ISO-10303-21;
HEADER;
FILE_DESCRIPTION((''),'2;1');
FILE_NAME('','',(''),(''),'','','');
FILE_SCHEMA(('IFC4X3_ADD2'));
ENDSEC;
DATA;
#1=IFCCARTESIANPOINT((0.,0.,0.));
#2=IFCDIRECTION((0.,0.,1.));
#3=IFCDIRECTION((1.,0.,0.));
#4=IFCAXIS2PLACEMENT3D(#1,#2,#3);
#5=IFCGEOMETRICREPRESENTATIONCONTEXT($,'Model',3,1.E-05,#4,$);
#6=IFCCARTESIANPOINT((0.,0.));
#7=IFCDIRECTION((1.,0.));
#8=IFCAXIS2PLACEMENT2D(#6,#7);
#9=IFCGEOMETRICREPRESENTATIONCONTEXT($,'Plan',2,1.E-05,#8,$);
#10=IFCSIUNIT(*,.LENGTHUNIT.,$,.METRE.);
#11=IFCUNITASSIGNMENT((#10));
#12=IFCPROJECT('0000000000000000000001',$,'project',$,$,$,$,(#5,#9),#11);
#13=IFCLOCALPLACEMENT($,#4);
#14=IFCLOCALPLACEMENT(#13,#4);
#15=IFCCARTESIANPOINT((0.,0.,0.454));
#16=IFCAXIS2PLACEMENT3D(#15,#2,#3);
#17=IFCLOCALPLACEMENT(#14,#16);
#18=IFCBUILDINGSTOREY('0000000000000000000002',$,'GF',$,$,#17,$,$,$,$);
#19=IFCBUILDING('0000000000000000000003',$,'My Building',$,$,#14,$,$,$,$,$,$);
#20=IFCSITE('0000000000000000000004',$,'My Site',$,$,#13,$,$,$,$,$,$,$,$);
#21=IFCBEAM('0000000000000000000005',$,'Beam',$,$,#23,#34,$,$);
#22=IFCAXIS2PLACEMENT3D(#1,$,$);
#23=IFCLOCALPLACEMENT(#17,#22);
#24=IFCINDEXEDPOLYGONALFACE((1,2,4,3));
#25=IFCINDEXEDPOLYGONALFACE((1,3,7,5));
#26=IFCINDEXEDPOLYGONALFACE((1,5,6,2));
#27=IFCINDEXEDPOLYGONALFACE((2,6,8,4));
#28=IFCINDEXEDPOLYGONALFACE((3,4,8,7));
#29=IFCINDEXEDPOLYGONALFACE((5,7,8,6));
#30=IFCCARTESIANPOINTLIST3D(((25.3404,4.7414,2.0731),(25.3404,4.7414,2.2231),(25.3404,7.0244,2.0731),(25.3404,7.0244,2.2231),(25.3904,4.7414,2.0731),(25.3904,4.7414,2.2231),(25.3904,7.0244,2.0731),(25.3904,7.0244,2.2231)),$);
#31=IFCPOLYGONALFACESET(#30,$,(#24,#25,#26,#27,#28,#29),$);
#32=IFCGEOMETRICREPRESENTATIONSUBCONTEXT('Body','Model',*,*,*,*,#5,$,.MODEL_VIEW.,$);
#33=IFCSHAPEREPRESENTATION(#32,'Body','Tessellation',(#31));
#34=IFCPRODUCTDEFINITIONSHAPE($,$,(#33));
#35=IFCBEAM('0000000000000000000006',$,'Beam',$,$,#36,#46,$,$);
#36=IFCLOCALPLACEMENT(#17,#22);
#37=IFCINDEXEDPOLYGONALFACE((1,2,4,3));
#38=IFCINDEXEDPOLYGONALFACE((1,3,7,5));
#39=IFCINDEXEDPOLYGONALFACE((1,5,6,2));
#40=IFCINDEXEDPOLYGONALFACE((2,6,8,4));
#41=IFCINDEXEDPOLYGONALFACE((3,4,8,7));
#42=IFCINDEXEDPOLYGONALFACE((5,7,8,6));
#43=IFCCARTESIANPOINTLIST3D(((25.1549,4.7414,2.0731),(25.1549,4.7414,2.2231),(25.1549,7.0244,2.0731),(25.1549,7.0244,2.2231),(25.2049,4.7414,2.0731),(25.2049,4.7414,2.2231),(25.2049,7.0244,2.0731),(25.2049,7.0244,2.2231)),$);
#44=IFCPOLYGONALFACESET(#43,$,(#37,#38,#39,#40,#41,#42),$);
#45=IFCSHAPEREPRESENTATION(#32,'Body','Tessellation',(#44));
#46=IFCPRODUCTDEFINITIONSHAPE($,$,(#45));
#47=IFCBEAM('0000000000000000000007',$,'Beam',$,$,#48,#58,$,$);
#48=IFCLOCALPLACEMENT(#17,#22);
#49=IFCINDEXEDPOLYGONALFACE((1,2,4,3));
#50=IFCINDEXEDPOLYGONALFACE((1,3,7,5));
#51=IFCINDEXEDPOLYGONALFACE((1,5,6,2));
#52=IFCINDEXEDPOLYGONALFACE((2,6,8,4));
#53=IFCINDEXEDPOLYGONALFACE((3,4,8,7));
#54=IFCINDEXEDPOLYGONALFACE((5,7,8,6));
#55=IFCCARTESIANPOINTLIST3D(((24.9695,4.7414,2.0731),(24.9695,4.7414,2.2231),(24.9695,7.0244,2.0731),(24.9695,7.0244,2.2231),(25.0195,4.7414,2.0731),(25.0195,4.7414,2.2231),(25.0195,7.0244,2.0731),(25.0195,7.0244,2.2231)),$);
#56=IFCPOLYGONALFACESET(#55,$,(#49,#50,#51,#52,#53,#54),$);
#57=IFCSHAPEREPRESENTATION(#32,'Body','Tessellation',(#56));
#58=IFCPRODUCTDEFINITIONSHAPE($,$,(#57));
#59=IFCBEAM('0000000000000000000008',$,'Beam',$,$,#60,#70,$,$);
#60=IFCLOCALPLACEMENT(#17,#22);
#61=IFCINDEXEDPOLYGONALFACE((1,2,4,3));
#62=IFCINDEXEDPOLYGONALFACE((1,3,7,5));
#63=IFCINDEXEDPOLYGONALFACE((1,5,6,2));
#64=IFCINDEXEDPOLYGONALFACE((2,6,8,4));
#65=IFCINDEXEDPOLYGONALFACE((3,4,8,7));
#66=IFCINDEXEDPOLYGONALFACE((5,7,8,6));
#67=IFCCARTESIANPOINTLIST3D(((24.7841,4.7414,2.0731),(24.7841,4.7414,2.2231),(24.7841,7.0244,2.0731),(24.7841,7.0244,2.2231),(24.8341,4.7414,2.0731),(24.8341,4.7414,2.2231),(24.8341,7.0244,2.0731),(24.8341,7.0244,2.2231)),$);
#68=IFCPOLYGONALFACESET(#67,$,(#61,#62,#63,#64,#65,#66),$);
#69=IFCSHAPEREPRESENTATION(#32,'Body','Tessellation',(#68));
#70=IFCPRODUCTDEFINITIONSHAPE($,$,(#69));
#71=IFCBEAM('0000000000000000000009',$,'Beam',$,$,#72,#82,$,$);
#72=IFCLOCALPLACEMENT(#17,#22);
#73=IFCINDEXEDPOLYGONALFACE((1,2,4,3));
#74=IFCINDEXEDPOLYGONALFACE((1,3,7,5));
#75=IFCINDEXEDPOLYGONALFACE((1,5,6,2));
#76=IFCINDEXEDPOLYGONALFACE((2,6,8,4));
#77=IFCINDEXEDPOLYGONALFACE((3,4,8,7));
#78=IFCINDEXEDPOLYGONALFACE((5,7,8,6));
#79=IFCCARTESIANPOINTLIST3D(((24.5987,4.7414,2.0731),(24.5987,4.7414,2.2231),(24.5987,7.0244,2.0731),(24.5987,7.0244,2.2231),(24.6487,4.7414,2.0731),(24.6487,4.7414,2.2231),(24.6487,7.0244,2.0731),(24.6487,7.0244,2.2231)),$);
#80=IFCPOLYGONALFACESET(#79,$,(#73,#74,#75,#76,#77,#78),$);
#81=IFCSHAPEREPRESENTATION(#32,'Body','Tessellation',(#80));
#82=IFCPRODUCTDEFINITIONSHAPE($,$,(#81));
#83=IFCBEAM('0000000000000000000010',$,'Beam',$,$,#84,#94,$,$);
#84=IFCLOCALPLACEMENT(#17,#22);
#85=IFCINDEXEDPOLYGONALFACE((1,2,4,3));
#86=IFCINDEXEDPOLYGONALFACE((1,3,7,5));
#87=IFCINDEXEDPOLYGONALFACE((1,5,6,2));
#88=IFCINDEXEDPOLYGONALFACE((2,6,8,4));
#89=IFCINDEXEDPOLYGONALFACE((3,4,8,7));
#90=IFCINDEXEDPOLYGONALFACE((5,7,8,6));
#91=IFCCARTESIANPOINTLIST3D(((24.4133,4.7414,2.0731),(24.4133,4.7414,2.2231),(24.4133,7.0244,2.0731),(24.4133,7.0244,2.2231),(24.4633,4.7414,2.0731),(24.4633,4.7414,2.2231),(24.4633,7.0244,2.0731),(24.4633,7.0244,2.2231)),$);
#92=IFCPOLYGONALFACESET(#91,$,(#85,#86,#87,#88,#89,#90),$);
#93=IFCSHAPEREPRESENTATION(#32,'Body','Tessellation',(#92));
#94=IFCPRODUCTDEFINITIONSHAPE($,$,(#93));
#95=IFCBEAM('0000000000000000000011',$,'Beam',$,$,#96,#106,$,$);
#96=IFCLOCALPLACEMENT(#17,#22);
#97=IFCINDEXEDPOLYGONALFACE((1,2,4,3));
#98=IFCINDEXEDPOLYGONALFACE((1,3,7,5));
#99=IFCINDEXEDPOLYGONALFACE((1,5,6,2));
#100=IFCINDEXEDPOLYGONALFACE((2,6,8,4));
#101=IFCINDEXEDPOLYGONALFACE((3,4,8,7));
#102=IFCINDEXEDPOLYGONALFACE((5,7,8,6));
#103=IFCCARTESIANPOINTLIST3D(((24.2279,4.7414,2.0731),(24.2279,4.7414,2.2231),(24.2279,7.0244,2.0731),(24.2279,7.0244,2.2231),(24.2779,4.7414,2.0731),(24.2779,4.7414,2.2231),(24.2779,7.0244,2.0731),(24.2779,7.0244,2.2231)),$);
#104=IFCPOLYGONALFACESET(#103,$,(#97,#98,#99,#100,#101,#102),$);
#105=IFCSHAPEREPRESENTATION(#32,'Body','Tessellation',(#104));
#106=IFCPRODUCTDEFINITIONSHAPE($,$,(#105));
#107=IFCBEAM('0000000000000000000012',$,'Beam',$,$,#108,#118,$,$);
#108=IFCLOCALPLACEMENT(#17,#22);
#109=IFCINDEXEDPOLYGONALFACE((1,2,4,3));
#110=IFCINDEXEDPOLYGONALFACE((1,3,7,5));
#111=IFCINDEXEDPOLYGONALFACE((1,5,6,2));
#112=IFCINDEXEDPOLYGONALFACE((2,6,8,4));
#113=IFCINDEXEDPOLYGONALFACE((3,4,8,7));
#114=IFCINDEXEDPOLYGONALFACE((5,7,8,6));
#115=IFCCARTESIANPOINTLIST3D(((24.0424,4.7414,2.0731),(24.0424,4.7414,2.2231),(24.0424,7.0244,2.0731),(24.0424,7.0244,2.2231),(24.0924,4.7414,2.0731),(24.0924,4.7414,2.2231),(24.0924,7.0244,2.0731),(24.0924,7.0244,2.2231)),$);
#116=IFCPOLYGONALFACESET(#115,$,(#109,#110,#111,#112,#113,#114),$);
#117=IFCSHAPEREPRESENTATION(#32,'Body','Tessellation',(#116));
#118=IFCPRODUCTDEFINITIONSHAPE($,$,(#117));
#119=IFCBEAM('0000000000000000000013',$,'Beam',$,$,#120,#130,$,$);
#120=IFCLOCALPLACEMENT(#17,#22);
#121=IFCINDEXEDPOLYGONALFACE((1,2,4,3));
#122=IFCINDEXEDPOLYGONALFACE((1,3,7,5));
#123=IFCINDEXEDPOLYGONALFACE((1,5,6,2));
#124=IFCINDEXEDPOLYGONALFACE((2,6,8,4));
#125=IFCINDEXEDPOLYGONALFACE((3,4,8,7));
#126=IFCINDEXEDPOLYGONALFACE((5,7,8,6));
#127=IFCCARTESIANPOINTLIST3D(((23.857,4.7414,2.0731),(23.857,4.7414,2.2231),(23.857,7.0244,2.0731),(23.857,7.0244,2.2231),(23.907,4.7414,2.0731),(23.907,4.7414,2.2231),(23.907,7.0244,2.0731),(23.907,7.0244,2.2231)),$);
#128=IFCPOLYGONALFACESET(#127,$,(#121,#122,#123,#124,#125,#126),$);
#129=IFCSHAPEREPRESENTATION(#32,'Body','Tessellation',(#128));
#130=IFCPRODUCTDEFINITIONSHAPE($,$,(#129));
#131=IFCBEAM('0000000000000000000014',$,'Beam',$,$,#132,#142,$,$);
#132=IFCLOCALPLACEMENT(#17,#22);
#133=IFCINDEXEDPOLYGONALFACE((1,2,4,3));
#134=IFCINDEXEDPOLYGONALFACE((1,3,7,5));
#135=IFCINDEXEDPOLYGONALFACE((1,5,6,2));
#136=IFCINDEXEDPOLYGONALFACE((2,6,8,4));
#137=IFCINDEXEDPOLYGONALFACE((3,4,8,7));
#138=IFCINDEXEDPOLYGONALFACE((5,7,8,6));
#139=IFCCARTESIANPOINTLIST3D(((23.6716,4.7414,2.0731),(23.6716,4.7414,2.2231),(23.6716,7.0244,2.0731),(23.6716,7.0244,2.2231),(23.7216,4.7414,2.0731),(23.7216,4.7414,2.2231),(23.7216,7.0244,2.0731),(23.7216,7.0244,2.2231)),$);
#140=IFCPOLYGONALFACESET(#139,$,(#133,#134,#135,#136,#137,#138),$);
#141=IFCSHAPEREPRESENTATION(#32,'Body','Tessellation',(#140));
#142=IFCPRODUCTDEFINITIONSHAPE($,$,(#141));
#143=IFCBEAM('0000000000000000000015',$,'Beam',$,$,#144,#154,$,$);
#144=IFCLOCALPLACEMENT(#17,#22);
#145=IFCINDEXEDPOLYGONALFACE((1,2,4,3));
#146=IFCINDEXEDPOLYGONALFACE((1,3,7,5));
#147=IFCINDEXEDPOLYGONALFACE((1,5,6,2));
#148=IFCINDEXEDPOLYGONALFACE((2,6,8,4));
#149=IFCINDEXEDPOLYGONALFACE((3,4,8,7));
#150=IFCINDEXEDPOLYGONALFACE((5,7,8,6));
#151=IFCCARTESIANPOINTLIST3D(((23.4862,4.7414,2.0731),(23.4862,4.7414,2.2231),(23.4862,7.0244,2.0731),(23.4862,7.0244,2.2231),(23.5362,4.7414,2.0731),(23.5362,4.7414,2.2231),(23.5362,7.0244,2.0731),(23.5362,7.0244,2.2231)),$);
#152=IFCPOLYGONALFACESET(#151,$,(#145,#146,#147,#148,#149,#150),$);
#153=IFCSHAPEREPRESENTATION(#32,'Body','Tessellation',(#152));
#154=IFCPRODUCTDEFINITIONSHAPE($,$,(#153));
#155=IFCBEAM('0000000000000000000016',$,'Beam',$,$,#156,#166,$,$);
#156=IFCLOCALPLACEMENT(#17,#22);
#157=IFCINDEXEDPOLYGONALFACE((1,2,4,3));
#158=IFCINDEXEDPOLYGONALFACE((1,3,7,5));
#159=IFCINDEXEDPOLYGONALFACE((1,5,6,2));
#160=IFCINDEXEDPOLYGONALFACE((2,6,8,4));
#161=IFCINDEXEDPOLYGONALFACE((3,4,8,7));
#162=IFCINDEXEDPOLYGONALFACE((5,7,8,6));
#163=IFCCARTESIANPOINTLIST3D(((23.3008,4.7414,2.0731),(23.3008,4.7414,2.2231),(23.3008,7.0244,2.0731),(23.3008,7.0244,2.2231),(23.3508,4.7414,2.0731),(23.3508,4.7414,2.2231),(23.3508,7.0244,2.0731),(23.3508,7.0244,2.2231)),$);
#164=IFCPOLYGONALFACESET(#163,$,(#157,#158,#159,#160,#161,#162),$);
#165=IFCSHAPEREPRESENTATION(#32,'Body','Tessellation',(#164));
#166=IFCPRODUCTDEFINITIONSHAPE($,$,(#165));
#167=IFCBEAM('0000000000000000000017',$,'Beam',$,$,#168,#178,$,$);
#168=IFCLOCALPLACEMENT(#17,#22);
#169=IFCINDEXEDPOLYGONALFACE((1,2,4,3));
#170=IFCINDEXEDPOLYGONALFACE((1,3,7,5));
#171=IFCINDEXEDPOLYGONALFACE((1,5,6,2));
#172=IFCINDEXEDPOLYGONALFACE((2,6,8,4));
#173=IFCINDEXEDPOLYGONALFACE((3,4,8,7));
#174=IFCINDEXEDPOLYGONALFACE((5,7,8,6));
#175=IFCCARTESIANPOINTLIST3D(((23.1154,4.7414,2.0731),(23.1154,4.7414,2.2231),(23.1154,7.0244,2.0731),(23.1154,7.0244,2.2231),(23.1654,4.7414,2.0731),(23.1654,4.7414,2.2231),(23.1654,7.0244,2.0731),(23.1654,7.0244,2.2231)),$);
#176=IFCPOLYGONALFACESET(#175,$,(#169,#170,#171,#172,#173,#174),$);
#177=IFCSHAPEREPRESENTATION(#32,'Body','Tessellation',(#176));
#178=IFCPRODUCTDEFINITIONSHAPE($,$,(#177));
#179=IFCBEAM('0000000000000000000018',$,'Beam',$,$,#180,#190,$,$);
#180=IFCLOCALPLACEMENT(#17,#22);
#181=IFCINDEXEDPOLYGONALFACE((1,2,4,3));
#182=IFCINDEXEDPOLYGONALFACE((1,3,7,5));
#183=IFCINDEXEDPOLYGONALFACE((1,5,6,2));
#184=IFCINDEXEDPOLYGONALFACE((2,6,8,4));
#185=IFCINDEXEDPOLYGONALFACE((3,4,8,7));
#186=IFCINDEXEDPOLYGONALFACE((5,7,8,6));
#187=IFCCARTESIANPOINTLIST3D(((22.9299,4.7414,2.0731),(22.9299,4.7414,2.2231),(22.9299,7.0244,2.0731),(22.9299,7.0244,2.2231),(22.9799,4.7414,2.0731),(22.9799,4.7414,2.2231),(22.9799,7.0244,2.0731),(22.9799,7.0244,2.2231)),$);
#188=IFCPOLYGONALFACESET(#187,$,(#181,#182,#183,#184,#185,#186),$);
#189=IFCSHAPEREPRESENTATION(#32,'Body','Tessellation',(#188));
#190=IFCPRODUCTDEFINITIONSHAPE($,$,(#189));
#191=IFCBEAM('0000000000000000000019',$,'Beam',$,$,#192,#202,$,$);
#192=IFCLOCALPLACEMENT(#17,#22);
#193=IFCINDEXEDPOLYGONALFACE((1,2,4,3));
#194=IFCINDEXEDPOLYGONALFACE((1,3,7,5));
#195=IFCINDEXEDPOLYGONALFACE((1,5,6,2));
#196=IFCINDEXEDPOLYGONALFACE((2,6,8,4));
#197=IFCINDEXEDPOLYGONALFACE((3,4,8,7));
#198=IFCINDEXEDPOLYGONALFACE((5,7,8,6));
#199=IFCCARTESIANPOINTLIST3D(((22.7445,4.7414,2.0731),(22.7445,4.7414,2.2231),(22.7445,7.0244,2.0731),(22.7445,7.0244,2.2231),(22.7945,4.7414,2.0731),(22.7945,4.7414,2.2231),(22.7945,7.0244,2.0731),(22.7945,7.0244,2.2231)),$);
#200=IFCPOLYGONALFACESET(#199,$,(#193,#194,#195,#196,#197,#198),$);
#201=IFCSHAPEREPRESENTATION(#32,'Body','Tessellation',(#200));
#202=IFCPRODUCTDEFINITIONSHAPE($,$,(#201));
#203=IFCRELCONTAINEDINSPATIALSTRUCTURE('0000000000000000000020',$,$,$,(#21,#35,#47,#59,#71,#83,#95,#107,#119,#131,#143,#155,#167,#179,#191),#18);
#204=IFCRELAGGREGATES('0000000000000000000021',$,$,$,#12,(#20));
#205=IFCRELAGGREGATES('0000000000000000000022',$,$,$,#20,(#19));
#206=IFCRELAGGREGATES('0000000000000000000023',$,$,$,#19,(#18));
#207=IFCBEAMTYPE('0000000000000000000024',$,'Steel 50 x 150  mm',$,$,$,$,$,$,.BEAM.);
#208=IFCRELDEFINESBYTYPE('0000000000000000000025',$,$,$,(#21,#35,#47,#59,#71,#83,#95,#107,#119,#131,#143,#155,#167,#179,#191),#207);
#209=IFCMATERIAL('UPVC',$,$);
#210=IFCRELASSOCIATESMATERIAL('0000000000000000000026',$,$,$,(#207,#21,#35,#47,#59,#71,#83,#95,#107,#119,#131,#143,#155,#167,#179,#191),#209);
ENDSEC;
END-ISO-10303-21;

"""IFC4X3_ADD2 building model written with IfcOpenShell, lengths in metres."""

from ifc_helpers import new_model, si_unit, frame, origin_with_axes, origin_2d_with_axis, place, context, subcontext, project, spatial, rectangle, extrude, material, material_profile, profile_set, profile_usage, type_object, element, save


model = new_model("IFC4X3_ADD2")

# Units and contexts
model_context = context("Model", 3, precision=1e-05, world=origin_with_axes())
plan_context = context("Plan", 2, precision=1e-05, world=origin_2d_with_axis())
body_context_1 = subcontext(model_context, "Body", "Model", "MODEL_VIEW")
ifc_project = project(units=[si_unit("LENGTHUNIT", "METRE")], contexts=[model_context, plan_context])

# Site, building, storey
site_placement = place(None, origin_with_axes())
site = spatial("IfcSite", under=ifc_project, at=site_placement, Name="My Site")
building_placement = place(site_placement, origin_with_axes())
building = spatial("IfcBuilding", under=site, at=building_placement, Name="My Building")
storey_placement = place(building_placement, frame((0.0, 0.0, 0.454), z_axis=(0.0, 0.0, 1.0), x_axis=(1.0, 0.0, 0.0)))
storey = spatial("IfcBuildingStorey", under=building, at=storey_placement, Name="GF")

# Beams
ifc_material_1 = material(Name="UPVC")
ifc_material_profile_1 = material_profile(ifc_material_1, rectangle(XDim=0.05, YDim=0.15))
ifc_profile_set_1 = profile_set([ifc_material_profile_1])
ifc_profile_usage_1 = profile_usage(ifc_profile_set_1)
beam_type_1 = type_object("IfcBeamType", Name="Steel 50 x 150  mm", PredefinedType="BEAM", material=ifc_profile_set_1)
beam_1_placement = place(storey_placement, frame((25.3654, 7.0244, 2.1481), z_axis=(0.0, -1.0, 0.0), x_axis=(1.0, 0.0, 0.0)))
element("IfcBeam", 1, at=beam_1_placement, inside=storey, type_object=beam_type_1, material=ifc_profile_usage_1, Name="Beam", context=body_context_1, shape_type="SweptSolid", body=[
    extrude(rectangle(XDim=0.05, YDim=0.15), origin_with_axes(), (0.0, 0.0, 1.0), 2.283),
])
ifc_profile_usage_2 = profile_usage(ifc_profile_set_1)
beam_2_placement = place(storey_placement, frame((25.1799, 7.0244, 2.1481), z_axis=(0.0, -1.0, 0.0), x_axis=(1.0, 0.0, 0.0)))
element("IfcBeam", 2, at=beam_2_placement, inside=storey, type_object=beam_type_1, material=ifc_profile_usage_2, Name="Beam", context=body_context_1, shape_type="SweptSolid", body=[
    extrude(rectangle(XDim=0.05, YDim=0.15), origin_with_axes(), (0.0, 0.0, 1.0), 2.283),
])
ifc_profile_usage_3 = profile_usage(ifc_profile_set_1)
beam_3_placement = place(storey_placement, frame((24.9945, 7.0244, 2.1481), z_axis=(0.0, -1.0, 0.0), x_axis=(1.0, 0.0, 0.0)))
element("IfcBeam", 3, at=beam_3_placement, inside=storey, type_object=beam_type_1, material=ifc_profile_usage_3, Name="Beam", context=body_context_1, shape_type="SweptSolid", body=[
    extrude(rectangle(XDim=0.05, YDim=0.15), origin_with_axes(), (0.0, 0.0, 1.0), 2.283),
])
ifc_profile_usage_4 = profile_usage(ifc_profile_set_1)
beam_4_placement = place(storey_placement, frame((24.8091, 7.0244, 2.1481), z_axis=(0.0, -1.0, 0.0), x_axis=(1.0, 0.0, 0.0)))
element("IfcBeam", 4, at=beam_4_placement, inside=storey, type_object=beam_type_1, material=ifc_profile_usage_4, Name="Beam", context=body_context_1, shape_type="SweptSolid", body=[
    extrude(rectangle(XDim=0.05, YDim=0.15), origin_with_axes(), (0.0, 0.0, 1.0), 2.283),
])
ifc_profile_usage_5 = profile_usage(ifc_profile_set_1)
beam_5_placement = place(storey_placement, frame((24.6237, 7.0244, 2.1481), z_axis=(0.0, -1.0, 0.0), x_axis=(1.0, 0.0, 0.0)))
element("IfcBeam", 5, at=beam_5_placement, inside=storey, type_object=beam_type_1, material=ifc_profile_usage_5, Name="Beam", context=body_context_1, shape_type="SweptSolid", body=[
    extrude(rectangle(XDim=0.05, YDim=0.15), origin_with_axes(), (0.0, 0.0, 1.0), 2.283),
])
ifc_profile_usage_6 = profile_usage(ifc_profile_set_1)
beam_6_placement = place(storey_placement, frame((24.4383, 7.0244, 2.1481), z_axis=(0.0, -1.0, 0.0), x_axis=(1.0, 0.0, 0.0)))
element("IfcBeam", 6, at=beam_6_placement, inside=storey, type_object=beam_type_1, material=ifc_profile_usage_6, Name="Beam", context=body_context_1, shape_type="SweptSolid", body=[
    extrude(rectangle(XDim=0.05, YDim=0.15), origin_with_axes(), (0.0, 0.0, 1.0), 2.283),
])
ifc_profile_usage_7 = profile_usage(ifc_profile_set_1)
beam_7_placement = place(storey_placement, frame((24.2529, 7.0244, 2.1481), z_axis=(0.0, -1.0, 0.0), x_axis=(1.0, 0.0, 0.0)))
element("IfcBeam", 7, at=beam_7_placement, inside=storey, type_object=beam_type_1, material=ifc_profile_usage_7, Name="Beam", context=body_context_1, shape_type="SweptSolid", body=[
    extrude(rectangle(XDim=0.05, YDim=0.15), origin_with_axes(), (0.0, 0.0, 1.0), 2.283),
])
ifc_profile_usage_8 = profile_usage(ifc_profile_set_1)
beam_8_placement = place(storey_placement, frame((24.0674, 7.0244, 2.1481), z_axis=(0.0, -1.0, 0.0), x_axis=(1.0, 0.0, 0.0)))
element("IfcBeam", 8, at=beam_8_placement, inside=storey, type_object=beam_type_1, material=ifc_profile_usage_8, Name="Beam", context=body_context_1, shape_type="SweptSolid", body=[
    extrude(rectangle(XDim=0.05, YDim=0.15), origin_with_axes(), (0.0, 0.0, 1.0), 2.283),
])
ifc_profile_usage_9 = profile_usage(ifc_profile_set_1)
beam_9_placement = place(storey_placement, frame((23.882, 7.0244, 2.1481), z_axis=(0.0, -1.0, 0.0), x_axis=(1.0, 0.0, 0.0)))
element("IfcBeam", 9, at=beam_9_placement, inside=storey, type_object=beam_type_1, material=ifc_profile_usage_9, Name="Beam", context=body_context_1, shape_type="SweptSolid", body=[
    extrude(rectangle(XDim=0.05, YDim=0.15), origin_with_axes(), (0.0, 0.0, 1.0), 2.283),
])
ifc_profile_usage_10 = profile_usage(ifc_profile_set_1)
beam_10_placement = place(storey_placement, frame((23.6966, 7.0244, 2.1481), z_axis=(0.0, -1.0, 0.0), x_axis=(1.0, 0.0, 0.0)))
element("IfcBeam", 10, at=beam_10_placement, inside=storey, type_object=beam_type_1, material=ifc_profile_usage_10, Name="Beam", context=body_context_1, shape_type="SweptSolid", body=[
    extrude(rectangle(XDim=0.05, YDim=0.15), origin_with_axes(), (0.0, 0.0, 1.0), 2.283),
])
ifc_profile_usage_11 = profile_usage(ifc_profile_set_1)
beam_11_placement = place(storey_placement, frame((23.5112, 7.0244, 2.1481), z_axis=(0.0, -1.0, 0.0), x_axis=(1.0, 0.0, 0.0)))
element("IfcBeam", 11, at=beam_11_placement, inside=storey, type_object=beam_type_1, material=ifc_profile_usage_11, Name="Beam", context=body_context_1, shape_type="SweptSolid", body=[
    extrude(rectangle(XDim=0.05, YDim=0.15), origin_with_axes(), (0.0, 0.0, 1.0), 2.283),
])
ifc_profile_usage_12 = profile_usage(ifc_profile_set_1)
beam_12_placement = place(storey_placement, frame((23.3258, 7.0244, 2.1481), z_axis=(0.0, -1.0, 0.0), x_axis=(1.0, 0.0, 0.0)))
element("IfcBeam", 12, at=beam_12_placement, inside=storey, type_object=beam_type_1, material=ifc_profile_usage_12, Name="Beam", context=body_context_1, shape_type="SweptSolid", body=[
    extrude(rectangle(XDim=0.05, YDim=0.15), origin_with_axes(), (0.0, 0.0, 1.0), 2.283),
])
ifc_profile_usage_13 = profile_usage(ifc_profile_set_1)
beam_13_placement = place(storey_placement, frame((23.1404, 7.0244, 2.1481), z_axis=(0.0, -1.0, 0.0), x_axis=(1.0, 0.0, 0.0)))
element("IfcBeam", 13, at=beam_13_placement, inside=storey, type_object=beam_type_1, material=ifc_profile_usage_13, Name="Beam", context=body_context_1, shape_type="SweptSolid", body=[
    extrude(rectangle(XDim=0.05, YDim=0.15), origin_with_axes(), (0.0, 0.0, 1.0), 2.283),
])
ifc_profile_usage_14 = profile_usage(ifc_profile_set_1)
beam_14_placement = place(storey_placement, frame((22.9549, 7.0244, 2.1481), z_axis=(0.0, -1.0, 0.0), x_axis=(1.0, 0.0, 0.0)))
element("IfcBeam", 14, at=beam_14_placement, inside=storey, type_object=beam_type_1, material=ifc_profile_usage_14, Name="Beam", context=body_context_1, shape_type="SweptSolid", body=[
    extrude(rectangle(XDim=0.05, YDim=0.15), origin_with_axes(), (0.0, 0.0, 1.0), 2.283),
])
ifc_profile_usage_15 = profile_usage(ifc_profile_set_1)
beam_15_placement = place(storey_placement, frame((22.7695, 7.0244, 2.1481), z_axis=(0.0, -1.0, 0.0), x_axis=(1.0, 0.0, 0.0)))
element("IfcBeam", 15, at=beam_15_placement, inside=storey, type_object=beam_type_1, material=ifc_profile_usage_15, Name="Beam", context=body_context_1, shape_type="SweptSolid", body=[
    extrude(rectangle(XDim=0.05, YDim=0.15), origin_with_axes(), (0.0, 0.0, 1.0), 2.283),
])

save(model, "model.ifc")
